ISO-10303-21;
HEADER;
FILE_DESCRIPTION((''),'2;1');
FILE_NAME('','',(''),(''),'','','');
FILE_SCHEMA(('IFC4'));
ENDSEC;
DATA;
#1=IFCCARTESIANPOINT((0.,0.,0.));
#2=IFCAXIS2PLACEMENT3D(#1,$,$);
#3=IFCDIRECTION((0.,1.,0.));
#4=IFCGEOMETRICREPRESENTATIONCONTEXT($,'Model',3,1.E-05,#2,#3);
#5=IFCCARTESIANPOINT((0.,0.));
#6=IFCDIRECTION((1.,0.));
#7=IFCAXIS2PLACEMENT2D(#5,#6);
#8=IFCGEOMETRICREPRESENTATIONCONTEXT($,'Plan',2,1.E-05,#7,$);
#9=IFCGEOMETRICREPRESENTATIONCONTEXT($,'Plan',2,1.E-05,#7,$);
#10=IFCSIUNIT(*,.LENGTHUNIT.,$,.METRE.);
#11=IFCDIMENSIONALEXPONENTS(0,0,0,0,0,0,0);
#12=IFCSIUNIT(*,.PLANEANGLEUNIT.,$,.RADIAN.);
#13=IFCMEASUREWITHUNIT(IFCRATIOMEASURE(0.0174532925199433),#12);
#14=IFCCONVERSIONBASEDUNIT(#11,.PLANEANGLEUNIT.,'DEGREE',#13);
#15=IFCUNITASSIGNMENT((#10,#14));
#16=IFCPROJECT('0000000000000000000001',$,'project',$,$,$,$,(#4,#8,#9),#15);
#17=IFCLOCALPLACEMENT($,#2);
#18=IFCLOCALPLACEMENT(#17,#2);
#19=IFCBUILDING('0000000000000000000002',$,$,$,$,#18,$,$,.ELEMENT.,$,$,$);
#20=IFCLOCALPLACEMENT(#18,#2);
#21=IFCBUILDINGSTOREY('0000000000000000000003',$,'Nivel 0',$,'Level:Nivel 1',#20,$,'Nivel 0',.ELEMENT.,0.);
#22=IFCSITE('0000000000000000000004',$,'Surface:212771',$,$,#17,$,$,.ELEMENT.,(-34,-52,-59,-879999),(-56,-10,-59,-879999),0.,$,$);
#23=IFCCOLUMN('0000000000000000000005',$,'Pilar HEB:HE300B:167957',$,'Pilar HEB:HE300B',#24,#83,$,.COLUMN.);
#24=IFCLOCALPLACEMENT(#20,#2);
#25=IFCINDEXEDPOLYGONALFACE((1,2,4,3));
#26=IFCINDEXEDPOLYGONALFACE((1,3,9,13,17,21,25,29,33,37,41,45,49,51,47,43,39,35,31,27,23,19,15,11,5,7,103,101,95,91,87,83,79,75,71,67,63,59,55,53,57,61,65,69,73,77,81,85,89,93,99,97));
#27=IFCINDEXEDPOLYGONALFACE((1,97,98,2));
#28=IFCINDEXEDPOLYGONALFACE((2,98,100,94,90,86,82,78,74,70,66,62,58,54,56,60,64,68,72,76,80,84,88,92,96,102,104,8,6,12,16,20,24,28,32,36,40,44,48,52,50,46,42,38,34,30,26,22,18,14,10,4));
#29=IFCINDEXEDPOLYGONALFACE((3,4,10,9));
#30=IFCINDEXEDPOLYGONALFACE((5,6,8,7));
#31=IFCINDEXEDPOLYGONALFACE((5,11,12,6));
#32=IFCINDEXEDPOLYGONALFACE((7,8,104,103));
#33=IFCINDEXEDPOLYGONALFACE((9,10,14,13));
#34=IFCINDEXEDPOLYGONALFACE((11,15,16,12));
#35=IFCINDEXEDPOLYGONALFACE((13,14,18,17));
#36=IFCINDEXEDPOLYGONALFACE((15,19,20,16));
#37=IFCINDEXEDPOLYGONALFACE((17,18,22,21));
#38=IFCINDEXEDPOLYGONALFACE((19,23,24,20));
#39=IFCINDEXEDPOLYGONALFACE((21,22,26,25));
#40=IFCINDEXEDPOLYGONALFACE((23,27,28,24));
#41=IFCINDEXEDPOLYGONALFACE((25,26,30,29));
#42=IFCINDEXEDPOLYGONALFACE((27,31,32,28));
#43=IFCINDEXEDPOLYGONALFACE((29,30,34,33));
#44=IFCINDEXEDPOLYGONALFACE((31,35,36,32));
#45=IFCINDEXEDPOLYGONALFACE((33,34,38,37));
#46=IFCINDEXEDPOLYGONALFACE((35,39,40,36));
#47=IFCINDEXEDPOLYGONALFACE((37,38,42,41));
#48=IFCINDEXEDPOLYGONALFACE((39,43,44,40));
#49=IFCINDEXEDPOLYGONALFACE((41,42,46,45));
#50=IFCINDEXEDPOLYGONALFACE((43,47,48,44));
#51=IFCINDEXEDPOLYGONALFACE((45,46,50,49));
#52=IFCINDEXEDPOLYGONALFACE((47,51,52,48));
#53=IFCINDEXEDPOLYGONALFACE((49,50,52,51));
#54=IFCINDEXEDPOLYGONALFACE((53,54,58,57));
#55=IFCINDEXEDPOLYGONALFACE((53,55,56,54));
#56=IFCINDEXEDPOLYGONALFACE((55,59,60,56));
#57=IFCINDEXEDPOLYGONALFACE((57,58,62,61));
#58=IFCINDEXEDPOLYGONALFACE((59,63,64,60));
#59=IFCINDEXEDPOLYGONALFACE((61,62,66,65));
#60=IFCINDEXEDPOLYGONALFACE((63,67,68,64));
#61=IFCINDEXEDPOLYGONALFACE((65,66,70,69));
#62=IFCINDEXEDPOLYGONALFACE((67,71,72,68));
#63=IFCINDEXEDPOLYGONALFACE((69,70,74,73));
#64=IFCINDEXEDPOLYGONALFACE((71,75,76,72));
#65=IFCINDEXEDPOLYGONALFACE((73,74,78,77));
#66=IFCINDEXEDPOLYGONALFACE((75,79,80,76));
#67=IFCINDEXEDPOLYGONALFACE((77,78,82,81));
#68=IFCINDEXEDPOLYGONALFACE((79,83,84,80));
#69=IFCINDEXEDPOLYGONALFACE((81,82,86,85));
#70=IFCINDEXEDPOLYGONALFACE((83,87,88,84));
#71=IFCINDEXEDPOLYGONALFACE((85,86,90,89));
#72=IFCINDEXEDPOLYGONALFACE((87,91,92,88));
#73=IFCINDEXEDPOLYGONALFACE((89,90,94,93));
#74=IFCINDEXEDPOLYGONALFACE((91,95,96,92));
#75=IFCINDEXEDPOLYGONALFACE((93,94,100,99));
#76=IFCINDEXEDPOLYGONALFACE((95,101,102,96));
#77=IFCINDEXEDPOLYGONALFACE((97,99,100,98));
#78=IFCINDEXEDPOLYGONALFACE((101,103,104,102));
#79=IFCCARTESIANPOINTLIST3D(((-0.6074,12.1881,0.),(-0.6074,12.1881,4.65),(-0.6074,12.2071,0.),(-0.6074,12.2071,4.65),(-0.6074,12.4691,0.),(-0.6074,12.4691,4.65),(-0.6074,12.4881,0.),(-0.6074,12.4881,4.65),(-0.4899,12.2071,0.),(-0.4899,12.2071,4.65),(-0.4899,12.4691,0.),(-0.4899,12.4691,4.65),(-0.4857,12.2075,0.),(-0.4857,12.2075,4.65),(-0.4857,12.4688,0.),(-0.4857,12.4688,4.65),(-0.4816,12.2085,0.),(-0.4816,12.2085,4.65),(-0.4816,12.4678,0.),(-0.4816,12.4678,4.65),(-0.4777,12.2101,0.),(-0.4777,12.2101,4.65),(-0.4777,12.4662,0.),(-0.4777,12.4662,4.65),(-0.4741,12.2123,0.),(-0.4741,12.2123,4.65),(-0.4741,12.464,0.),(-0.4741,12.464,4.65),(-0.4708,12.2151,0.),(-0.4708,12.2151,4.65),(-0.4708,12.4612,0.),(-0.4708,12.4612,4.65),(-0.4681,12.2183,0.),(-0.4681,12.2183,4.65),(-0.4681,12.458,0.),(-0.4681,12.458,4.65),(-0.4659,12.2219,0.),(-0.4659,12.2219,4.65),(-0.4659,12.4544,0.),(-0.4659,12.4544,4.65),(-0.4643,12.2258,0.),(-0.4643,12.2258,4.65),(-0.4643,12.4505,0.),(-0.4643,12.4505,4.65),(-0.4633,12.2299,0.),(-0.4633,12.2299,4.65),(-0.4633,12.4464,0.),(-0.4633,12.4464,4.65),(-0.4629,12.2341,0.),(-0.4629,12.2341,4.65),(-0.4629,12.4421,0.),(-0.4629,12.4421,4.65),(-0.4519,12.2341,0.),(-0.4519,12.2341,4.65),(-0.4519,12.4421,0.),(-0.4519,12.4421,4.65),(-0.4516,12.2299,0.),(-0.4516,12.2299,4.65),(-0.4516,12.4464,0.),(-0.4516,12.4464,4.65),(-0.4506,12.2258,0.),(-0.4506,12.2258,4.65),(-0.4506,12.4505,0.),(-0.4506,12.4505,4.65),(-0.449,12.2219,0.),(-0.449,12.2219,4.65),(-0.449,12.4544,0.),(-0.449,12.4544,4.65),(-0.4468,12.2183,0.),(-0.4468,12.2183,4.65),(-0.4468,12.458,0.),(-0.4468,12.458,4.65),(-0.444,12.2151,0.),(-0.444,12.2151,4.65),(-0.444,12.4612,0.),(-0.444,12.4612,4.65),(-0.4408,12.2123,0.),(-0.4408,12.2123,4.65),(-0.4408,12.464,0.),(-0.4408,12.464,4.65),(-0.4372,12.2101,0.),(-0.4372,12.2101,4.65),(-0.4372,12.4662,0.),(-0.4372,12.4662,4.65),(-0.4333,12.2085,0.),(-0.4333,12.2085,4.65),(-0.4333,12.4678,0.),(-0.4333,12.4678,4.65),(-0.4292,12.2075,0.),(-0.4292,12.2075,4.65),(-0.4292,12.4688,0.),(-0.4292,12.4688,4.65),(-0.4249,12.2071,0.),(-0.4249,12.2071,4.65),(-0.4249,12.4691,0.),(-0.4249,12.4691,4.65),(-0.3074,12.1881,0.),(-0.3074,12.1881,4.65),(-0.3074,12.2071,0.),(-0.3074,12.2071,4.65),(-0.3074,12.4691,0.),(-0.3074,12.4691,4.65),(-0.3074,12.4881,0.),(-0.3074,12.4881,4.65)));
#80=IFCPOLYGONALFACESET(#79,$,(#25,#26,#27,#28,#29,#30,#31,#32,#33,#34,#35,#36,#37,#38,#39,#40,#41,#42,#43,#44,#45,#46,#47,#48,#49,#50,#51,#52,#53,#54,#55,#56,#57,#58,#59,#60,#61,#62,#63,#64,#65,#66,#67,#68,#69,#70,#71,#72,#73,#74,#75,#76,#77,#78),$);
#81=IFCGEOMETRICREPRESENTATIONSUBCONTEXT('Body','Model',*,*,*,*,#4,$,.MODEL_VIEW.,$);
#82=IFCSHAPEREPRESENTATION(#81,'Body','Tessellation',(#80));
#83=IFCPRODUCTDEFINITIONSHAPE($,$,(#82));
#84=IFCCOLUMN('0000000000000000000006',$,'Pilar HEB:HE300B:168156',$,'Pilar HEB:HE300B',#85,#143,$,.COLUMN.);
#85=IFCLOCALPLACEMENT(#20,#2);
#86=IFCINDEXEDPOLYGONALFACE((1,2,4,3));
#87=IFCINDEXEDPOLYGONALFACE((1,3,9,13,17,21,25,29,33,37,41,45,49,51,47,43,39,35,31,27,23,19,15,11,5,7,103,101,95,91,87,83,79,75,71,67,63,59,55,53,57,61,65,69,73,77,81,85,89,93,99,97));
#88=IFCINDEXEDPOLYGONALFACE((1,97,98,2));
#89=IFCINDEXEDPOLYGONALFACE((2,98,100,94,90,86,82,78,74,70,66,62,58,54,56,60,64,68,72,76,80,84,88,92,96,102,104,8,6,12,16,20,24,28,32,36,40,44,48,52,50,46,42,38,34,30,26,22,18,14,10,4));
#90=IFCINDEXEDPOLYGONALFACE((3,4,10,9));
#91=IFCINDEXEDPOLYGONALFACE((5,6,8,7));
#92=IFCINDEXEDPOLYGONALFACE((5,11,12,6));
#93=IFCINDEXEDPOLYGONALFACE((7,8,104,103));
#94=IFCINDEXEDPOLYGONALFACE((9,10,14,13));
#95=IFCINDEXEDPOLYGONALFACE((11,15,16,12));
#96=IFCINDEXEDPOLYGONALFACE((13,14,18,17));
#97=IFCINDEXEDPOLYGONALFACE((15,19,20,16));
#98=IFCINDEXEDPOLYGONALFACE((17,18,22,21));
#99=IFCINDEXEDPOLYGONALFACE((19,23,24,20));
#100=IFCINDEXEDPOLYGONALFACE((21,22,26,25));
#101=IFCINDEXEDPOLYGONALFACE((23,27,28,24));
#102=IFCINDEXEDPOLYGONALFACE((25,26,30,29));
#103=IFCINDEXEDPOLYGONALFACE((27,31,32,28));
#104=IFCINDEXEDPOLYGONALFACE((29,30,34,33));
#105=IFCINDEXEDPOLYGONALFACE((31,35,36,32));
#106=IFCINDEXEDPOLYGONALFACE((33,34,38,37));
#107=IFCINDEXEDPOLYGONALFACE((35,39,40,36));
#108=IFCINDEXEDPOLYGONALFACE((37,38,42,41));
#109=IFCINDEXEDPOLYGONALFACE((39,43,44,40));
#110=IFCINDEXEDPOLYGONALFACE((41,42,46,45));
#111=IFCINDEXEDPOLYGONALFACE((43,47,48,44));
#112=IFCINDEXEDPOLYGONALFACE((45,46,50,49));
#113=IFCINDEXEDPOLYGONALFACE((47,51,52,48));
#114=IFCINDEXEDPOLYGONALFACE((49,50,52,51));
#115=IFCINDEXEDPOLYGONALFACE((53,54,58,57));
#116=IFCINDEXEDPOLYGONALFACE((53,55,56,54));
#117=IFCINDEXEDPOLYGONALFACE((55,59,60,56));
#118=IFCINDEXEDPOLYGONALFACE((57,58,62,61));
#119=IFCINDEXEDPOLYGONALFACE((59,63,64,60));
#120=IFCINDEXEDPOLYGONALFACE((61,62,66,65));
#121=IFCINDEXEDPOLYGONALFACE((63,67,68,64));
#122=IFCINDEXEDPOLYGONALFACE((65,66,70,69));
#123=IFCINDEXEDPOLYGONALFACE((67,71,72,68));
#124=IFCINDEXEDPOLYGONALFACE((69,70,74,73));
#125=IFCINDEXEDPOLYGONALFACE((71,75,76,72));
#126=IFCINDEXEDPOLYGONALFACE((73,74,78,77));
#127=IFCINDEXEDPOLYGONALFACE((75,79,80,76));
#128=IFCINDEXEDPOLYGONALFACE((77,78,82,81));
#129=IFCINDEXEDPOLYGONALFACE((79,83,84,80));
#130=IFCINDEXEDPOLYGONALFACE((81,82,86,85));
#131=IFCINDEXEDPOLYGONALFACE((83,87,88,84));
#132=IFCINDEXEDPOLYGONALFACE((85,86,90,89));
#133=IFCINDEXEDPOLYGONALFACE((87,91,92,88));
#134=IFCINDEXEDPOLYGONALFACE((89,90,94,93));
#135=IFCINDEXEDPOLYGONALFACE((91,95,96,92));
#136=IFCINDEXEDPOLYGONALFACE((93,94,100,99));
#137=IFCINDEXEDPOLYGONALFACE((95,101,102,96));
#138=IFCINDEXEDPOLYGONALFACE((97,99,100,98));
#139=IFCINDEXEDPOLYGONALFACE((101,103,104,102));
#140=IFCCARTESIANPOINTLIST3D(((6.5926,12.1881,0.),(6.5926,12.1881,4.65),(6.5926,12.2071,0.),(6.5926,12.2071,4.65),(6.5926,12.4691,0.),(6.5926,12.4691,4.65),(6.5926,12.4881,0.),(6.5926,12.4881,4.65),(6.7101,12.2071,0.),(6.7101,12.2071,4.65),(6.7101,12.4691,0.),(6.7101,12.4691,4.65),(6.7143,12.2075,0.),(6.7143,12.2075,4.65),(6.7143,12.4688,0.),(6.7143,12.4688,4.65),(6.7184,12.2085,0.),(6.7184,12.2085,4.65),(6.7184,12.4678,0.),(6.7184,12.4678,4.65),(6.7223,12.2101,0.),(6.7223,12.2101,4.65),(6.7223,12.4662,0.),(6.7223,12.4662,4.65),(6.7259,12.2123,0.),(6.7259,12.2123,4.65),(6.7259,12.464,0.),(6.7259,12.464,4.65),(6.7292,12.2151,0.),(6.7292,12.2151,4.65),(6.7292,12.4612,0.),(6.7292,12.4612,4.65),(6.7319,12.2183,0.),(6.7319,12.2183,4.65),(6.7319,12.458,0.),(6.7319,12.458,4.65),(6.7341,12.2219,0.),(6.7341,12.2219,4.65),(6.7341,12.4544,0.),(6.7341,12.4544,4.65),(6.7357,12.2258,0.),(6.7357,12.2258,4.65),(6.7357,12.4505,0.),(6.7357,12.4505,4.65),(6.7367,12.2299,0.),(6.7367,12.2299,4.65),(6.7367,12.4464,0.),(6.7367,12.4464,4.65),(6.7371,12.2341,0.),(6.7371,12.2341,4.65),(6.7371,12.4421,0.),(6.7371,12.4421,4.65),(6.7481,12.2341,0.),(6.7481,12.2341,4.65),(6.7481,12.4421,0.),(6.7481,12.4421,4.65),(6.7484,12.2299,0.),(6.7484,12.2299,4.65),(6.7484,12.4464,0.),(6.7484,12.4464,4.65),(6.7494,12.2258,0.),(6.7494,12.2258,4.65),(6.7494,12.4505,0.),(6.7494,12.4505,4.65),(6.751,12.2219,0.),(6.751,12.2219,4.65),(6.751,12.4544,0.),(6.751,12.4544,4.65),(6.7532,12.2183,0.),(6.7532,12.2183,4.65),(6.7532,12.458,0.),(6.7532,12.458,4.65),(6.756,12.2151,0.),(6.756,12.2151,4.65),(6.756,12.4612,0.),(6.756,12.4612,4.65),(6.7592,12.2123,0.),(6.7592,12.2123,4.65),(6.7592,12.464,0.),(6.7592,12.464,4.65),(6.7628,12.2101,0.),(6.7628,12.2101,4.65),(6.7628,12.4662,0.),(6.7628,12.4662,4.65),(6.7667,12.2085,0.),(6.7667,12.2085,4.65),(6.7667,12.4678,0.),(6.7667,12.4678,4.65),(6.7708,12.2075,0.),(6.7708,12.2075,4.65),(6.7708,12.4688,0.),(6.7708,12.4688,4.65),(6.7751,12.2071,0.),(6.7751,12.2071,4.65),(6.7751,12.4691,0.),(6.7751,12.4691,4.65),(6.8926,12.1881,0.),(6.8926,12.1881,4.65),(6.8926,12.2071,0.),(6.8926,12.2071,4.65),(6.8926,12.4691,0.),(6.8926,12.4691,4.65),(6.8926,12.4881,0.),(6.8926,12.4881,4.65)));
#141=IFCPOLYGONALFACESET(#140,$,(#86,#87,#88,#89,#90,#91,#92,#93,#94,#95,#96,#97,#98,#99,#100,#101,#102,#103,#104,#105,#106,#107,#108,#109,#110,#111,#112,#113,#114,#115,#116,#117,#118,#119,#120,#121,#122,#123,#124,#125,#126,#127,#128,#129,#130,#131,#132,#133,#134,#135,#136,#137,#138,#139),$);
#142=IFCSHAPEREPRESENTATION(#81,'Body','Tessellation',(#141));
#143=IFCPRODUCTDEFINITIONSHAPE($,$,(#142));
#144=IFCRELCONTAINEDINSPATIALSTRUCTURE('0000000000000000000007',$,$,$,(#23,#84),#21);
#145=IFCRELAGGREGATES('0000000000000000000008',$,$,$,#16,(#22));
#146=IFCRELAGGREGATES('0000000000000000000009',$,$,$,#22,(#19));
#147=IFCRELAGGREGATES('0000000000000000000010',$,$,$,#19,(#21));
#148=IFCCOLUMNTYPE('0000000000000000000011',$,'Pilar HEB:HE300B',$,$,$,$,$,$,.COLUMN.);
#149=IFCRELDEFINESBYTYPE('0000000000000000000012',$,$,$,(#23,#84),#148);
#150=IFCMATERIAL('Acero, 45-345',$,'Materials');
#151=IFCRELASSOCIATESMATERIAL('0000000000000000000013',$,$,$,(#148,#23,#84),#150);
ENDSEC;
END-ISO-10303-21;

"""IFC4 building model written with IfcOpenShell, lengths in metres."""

from ifc_helpers import new_model, entity, si_unit, converted_unit, direction, frame, origin, origin_2d_with_axis, place, context, subcontext, project, spatial, polyline, outline, extrude, source, transform, mapped, material, type_object, type_shapes, element, save


model = new_model("IFC4")

# Units and contexts
model_context = context("Model", 3, precision=1e-05, world=origin(), true_north=direction((0.0, 1.0, 0.0)))
plan_context_1 = context("Plan", 2, precision=1e-05, world=origin_2d_with_axis())
plan_context_2 = context("Plan", 2, precision=1e-05, world=origin_2d_with_axis())
body_context = subcontext(model_context, "Body", "Model", "MODEL_VIEW")
ifc_project = project(units=[si_unit("LENGTHUNIT", "METRE"), converted_unit("PLANEANGLEUNIT", "DEGREE", entity("IfcRatioMeasure", 0.0174532925199433), si_unit("PLANEANGLEUNIT", "RADIAN"), dimensions=[0, 0, 0, 0, 0, 0, 0])], contexts=[model_context, plan_context_1, plan_context_2])

# Site, building, storey
site_placement = place(None, origin())
site = spatial("IfcSite", under=ifc_project, at=site_placement, Name="Surface:212771", CompositionType="ELEMENT", RefLatitude=(-34, -52, -59, -879999), RefLongitude=(-56, -10, -59, -879999), RefElevation=0.0)
building_placement = place(site_placement, origin())
building = spatial("IfcBuilding", under=site, at=building_placement, CompositionType="ELEMENT")
storey_placement = place(building_placement, origin())
storey = spatial("IfcBuildingStorey", under=building, at=storey_placement, Name="Nivel 0", ObjectType="Level:Nivel 1", LongName="Nivel 0", CompositionType="ELEMENT", Elevation=0.0)

# Columns
ifc_material_1 = material(Name="Acero, 45-345", Category="Materials")
column_type_1 = type_object("IfcColumnType", Name="Pilar HEB:HE300B", PredefinedType="COLUMN", material=ifc_material_1)
shared_shape_1 = source(origin(), body_context, "Body", "SweptSolid", [
    extrude(outline(polyline([(0.1041, 0.0), (0.1084, -0.0001), (0.1125, -0.0009), (0.1165, -0.0023), (0.1203, -0.0043), (0.1236, -0.0069), (0.1265, -0.01), (0.1289, -0.0135), (0.1308, -0.0173), (0.132, -0.0213), (0.1325, -0.0255), (0.1387, -0.1429), (0.1577, -0.1419), (0.1419, 0.1577), (0.1229, 0.1567), (0.1291, 0.0394), (0.129, 0.0351), (0.1282, 0.031), (0.1268, 0.027), (0.1248, 0.0233), (0.1222, 0.0199), (0.1191, 0.017), (0.1156, 0.0146), (0.1118, 0.0127), (0.1078, 0.0115), (0.1036, 0.011), (-0.1041, 0.0), (-0.1084, 0.0001), (-0.1125, 0.0009), (-0.1165, 0.0023), (-0.1203, 0.0043), (-0.1236, 0.0069), (-0.1265, 0.01), (-0.1289, 0.0135), (-0.1308, 0.0173), (-0.132, 0.0213), (-0.1325, 0.0255), (-0.1387, 0.1429), (-0.1577, 0.1419), (-0.1419, -0.1577), (-0.1229, -0.1567), (-0.1291, -0.0394), (-0.129, -0.0351), (-0.1282, -0.031), (-0.1268, -0.027), (-0.1248, -0.0233), (-0.1222, -0.0199), (-0.1191, -0.017), (-0.1156, -0.0146), (-0.1118, -0.0127), (-0.1078, -0.0115), (-0.1036, -0.011), (0.1041, 0.0)])), frame((0.0, 0.0, 0.0), z_axis=(0.0, 0.0, -1.0), x_axis=(0.052811, -0.998605, 0.0)), (0.0, 0.0, -1.0), 4.65),
])
type_shapes(column_type_1, [shared_shape_1])
for number, where, z_axis, x_axis, name in (
    (1, (-0.4574, 12.3381, 0.0), (0.0, 0.0, 2.138143), (1.0, 0.0, 0.0), "Pilar HEB:HE300B:167957"),
    (2, (6.7426, 12.3381, 0.0), (0.0, 0.0, 2.137115), (1.0, 0.0, 0.0), "Pilar HEB:HE300B:168156"),
):
    element("IfcColumn", number, at=place(storey_placement, frame(where, z_axis=z_axis, x_axis=x_axis)), inside=storey, type_object=column_type_1, material=ifc_material_1, Name=name, ObjectType="Pilar HEB:HE300B", PredefinedType="COLUMN", context=body_context, shape_type="MappedRepresentation", body=[
        mapped(shared_shape_1, transform((0.0, 0.0, 0.0), scale=1.0)),
    ])

save(model, "model.ifc")
